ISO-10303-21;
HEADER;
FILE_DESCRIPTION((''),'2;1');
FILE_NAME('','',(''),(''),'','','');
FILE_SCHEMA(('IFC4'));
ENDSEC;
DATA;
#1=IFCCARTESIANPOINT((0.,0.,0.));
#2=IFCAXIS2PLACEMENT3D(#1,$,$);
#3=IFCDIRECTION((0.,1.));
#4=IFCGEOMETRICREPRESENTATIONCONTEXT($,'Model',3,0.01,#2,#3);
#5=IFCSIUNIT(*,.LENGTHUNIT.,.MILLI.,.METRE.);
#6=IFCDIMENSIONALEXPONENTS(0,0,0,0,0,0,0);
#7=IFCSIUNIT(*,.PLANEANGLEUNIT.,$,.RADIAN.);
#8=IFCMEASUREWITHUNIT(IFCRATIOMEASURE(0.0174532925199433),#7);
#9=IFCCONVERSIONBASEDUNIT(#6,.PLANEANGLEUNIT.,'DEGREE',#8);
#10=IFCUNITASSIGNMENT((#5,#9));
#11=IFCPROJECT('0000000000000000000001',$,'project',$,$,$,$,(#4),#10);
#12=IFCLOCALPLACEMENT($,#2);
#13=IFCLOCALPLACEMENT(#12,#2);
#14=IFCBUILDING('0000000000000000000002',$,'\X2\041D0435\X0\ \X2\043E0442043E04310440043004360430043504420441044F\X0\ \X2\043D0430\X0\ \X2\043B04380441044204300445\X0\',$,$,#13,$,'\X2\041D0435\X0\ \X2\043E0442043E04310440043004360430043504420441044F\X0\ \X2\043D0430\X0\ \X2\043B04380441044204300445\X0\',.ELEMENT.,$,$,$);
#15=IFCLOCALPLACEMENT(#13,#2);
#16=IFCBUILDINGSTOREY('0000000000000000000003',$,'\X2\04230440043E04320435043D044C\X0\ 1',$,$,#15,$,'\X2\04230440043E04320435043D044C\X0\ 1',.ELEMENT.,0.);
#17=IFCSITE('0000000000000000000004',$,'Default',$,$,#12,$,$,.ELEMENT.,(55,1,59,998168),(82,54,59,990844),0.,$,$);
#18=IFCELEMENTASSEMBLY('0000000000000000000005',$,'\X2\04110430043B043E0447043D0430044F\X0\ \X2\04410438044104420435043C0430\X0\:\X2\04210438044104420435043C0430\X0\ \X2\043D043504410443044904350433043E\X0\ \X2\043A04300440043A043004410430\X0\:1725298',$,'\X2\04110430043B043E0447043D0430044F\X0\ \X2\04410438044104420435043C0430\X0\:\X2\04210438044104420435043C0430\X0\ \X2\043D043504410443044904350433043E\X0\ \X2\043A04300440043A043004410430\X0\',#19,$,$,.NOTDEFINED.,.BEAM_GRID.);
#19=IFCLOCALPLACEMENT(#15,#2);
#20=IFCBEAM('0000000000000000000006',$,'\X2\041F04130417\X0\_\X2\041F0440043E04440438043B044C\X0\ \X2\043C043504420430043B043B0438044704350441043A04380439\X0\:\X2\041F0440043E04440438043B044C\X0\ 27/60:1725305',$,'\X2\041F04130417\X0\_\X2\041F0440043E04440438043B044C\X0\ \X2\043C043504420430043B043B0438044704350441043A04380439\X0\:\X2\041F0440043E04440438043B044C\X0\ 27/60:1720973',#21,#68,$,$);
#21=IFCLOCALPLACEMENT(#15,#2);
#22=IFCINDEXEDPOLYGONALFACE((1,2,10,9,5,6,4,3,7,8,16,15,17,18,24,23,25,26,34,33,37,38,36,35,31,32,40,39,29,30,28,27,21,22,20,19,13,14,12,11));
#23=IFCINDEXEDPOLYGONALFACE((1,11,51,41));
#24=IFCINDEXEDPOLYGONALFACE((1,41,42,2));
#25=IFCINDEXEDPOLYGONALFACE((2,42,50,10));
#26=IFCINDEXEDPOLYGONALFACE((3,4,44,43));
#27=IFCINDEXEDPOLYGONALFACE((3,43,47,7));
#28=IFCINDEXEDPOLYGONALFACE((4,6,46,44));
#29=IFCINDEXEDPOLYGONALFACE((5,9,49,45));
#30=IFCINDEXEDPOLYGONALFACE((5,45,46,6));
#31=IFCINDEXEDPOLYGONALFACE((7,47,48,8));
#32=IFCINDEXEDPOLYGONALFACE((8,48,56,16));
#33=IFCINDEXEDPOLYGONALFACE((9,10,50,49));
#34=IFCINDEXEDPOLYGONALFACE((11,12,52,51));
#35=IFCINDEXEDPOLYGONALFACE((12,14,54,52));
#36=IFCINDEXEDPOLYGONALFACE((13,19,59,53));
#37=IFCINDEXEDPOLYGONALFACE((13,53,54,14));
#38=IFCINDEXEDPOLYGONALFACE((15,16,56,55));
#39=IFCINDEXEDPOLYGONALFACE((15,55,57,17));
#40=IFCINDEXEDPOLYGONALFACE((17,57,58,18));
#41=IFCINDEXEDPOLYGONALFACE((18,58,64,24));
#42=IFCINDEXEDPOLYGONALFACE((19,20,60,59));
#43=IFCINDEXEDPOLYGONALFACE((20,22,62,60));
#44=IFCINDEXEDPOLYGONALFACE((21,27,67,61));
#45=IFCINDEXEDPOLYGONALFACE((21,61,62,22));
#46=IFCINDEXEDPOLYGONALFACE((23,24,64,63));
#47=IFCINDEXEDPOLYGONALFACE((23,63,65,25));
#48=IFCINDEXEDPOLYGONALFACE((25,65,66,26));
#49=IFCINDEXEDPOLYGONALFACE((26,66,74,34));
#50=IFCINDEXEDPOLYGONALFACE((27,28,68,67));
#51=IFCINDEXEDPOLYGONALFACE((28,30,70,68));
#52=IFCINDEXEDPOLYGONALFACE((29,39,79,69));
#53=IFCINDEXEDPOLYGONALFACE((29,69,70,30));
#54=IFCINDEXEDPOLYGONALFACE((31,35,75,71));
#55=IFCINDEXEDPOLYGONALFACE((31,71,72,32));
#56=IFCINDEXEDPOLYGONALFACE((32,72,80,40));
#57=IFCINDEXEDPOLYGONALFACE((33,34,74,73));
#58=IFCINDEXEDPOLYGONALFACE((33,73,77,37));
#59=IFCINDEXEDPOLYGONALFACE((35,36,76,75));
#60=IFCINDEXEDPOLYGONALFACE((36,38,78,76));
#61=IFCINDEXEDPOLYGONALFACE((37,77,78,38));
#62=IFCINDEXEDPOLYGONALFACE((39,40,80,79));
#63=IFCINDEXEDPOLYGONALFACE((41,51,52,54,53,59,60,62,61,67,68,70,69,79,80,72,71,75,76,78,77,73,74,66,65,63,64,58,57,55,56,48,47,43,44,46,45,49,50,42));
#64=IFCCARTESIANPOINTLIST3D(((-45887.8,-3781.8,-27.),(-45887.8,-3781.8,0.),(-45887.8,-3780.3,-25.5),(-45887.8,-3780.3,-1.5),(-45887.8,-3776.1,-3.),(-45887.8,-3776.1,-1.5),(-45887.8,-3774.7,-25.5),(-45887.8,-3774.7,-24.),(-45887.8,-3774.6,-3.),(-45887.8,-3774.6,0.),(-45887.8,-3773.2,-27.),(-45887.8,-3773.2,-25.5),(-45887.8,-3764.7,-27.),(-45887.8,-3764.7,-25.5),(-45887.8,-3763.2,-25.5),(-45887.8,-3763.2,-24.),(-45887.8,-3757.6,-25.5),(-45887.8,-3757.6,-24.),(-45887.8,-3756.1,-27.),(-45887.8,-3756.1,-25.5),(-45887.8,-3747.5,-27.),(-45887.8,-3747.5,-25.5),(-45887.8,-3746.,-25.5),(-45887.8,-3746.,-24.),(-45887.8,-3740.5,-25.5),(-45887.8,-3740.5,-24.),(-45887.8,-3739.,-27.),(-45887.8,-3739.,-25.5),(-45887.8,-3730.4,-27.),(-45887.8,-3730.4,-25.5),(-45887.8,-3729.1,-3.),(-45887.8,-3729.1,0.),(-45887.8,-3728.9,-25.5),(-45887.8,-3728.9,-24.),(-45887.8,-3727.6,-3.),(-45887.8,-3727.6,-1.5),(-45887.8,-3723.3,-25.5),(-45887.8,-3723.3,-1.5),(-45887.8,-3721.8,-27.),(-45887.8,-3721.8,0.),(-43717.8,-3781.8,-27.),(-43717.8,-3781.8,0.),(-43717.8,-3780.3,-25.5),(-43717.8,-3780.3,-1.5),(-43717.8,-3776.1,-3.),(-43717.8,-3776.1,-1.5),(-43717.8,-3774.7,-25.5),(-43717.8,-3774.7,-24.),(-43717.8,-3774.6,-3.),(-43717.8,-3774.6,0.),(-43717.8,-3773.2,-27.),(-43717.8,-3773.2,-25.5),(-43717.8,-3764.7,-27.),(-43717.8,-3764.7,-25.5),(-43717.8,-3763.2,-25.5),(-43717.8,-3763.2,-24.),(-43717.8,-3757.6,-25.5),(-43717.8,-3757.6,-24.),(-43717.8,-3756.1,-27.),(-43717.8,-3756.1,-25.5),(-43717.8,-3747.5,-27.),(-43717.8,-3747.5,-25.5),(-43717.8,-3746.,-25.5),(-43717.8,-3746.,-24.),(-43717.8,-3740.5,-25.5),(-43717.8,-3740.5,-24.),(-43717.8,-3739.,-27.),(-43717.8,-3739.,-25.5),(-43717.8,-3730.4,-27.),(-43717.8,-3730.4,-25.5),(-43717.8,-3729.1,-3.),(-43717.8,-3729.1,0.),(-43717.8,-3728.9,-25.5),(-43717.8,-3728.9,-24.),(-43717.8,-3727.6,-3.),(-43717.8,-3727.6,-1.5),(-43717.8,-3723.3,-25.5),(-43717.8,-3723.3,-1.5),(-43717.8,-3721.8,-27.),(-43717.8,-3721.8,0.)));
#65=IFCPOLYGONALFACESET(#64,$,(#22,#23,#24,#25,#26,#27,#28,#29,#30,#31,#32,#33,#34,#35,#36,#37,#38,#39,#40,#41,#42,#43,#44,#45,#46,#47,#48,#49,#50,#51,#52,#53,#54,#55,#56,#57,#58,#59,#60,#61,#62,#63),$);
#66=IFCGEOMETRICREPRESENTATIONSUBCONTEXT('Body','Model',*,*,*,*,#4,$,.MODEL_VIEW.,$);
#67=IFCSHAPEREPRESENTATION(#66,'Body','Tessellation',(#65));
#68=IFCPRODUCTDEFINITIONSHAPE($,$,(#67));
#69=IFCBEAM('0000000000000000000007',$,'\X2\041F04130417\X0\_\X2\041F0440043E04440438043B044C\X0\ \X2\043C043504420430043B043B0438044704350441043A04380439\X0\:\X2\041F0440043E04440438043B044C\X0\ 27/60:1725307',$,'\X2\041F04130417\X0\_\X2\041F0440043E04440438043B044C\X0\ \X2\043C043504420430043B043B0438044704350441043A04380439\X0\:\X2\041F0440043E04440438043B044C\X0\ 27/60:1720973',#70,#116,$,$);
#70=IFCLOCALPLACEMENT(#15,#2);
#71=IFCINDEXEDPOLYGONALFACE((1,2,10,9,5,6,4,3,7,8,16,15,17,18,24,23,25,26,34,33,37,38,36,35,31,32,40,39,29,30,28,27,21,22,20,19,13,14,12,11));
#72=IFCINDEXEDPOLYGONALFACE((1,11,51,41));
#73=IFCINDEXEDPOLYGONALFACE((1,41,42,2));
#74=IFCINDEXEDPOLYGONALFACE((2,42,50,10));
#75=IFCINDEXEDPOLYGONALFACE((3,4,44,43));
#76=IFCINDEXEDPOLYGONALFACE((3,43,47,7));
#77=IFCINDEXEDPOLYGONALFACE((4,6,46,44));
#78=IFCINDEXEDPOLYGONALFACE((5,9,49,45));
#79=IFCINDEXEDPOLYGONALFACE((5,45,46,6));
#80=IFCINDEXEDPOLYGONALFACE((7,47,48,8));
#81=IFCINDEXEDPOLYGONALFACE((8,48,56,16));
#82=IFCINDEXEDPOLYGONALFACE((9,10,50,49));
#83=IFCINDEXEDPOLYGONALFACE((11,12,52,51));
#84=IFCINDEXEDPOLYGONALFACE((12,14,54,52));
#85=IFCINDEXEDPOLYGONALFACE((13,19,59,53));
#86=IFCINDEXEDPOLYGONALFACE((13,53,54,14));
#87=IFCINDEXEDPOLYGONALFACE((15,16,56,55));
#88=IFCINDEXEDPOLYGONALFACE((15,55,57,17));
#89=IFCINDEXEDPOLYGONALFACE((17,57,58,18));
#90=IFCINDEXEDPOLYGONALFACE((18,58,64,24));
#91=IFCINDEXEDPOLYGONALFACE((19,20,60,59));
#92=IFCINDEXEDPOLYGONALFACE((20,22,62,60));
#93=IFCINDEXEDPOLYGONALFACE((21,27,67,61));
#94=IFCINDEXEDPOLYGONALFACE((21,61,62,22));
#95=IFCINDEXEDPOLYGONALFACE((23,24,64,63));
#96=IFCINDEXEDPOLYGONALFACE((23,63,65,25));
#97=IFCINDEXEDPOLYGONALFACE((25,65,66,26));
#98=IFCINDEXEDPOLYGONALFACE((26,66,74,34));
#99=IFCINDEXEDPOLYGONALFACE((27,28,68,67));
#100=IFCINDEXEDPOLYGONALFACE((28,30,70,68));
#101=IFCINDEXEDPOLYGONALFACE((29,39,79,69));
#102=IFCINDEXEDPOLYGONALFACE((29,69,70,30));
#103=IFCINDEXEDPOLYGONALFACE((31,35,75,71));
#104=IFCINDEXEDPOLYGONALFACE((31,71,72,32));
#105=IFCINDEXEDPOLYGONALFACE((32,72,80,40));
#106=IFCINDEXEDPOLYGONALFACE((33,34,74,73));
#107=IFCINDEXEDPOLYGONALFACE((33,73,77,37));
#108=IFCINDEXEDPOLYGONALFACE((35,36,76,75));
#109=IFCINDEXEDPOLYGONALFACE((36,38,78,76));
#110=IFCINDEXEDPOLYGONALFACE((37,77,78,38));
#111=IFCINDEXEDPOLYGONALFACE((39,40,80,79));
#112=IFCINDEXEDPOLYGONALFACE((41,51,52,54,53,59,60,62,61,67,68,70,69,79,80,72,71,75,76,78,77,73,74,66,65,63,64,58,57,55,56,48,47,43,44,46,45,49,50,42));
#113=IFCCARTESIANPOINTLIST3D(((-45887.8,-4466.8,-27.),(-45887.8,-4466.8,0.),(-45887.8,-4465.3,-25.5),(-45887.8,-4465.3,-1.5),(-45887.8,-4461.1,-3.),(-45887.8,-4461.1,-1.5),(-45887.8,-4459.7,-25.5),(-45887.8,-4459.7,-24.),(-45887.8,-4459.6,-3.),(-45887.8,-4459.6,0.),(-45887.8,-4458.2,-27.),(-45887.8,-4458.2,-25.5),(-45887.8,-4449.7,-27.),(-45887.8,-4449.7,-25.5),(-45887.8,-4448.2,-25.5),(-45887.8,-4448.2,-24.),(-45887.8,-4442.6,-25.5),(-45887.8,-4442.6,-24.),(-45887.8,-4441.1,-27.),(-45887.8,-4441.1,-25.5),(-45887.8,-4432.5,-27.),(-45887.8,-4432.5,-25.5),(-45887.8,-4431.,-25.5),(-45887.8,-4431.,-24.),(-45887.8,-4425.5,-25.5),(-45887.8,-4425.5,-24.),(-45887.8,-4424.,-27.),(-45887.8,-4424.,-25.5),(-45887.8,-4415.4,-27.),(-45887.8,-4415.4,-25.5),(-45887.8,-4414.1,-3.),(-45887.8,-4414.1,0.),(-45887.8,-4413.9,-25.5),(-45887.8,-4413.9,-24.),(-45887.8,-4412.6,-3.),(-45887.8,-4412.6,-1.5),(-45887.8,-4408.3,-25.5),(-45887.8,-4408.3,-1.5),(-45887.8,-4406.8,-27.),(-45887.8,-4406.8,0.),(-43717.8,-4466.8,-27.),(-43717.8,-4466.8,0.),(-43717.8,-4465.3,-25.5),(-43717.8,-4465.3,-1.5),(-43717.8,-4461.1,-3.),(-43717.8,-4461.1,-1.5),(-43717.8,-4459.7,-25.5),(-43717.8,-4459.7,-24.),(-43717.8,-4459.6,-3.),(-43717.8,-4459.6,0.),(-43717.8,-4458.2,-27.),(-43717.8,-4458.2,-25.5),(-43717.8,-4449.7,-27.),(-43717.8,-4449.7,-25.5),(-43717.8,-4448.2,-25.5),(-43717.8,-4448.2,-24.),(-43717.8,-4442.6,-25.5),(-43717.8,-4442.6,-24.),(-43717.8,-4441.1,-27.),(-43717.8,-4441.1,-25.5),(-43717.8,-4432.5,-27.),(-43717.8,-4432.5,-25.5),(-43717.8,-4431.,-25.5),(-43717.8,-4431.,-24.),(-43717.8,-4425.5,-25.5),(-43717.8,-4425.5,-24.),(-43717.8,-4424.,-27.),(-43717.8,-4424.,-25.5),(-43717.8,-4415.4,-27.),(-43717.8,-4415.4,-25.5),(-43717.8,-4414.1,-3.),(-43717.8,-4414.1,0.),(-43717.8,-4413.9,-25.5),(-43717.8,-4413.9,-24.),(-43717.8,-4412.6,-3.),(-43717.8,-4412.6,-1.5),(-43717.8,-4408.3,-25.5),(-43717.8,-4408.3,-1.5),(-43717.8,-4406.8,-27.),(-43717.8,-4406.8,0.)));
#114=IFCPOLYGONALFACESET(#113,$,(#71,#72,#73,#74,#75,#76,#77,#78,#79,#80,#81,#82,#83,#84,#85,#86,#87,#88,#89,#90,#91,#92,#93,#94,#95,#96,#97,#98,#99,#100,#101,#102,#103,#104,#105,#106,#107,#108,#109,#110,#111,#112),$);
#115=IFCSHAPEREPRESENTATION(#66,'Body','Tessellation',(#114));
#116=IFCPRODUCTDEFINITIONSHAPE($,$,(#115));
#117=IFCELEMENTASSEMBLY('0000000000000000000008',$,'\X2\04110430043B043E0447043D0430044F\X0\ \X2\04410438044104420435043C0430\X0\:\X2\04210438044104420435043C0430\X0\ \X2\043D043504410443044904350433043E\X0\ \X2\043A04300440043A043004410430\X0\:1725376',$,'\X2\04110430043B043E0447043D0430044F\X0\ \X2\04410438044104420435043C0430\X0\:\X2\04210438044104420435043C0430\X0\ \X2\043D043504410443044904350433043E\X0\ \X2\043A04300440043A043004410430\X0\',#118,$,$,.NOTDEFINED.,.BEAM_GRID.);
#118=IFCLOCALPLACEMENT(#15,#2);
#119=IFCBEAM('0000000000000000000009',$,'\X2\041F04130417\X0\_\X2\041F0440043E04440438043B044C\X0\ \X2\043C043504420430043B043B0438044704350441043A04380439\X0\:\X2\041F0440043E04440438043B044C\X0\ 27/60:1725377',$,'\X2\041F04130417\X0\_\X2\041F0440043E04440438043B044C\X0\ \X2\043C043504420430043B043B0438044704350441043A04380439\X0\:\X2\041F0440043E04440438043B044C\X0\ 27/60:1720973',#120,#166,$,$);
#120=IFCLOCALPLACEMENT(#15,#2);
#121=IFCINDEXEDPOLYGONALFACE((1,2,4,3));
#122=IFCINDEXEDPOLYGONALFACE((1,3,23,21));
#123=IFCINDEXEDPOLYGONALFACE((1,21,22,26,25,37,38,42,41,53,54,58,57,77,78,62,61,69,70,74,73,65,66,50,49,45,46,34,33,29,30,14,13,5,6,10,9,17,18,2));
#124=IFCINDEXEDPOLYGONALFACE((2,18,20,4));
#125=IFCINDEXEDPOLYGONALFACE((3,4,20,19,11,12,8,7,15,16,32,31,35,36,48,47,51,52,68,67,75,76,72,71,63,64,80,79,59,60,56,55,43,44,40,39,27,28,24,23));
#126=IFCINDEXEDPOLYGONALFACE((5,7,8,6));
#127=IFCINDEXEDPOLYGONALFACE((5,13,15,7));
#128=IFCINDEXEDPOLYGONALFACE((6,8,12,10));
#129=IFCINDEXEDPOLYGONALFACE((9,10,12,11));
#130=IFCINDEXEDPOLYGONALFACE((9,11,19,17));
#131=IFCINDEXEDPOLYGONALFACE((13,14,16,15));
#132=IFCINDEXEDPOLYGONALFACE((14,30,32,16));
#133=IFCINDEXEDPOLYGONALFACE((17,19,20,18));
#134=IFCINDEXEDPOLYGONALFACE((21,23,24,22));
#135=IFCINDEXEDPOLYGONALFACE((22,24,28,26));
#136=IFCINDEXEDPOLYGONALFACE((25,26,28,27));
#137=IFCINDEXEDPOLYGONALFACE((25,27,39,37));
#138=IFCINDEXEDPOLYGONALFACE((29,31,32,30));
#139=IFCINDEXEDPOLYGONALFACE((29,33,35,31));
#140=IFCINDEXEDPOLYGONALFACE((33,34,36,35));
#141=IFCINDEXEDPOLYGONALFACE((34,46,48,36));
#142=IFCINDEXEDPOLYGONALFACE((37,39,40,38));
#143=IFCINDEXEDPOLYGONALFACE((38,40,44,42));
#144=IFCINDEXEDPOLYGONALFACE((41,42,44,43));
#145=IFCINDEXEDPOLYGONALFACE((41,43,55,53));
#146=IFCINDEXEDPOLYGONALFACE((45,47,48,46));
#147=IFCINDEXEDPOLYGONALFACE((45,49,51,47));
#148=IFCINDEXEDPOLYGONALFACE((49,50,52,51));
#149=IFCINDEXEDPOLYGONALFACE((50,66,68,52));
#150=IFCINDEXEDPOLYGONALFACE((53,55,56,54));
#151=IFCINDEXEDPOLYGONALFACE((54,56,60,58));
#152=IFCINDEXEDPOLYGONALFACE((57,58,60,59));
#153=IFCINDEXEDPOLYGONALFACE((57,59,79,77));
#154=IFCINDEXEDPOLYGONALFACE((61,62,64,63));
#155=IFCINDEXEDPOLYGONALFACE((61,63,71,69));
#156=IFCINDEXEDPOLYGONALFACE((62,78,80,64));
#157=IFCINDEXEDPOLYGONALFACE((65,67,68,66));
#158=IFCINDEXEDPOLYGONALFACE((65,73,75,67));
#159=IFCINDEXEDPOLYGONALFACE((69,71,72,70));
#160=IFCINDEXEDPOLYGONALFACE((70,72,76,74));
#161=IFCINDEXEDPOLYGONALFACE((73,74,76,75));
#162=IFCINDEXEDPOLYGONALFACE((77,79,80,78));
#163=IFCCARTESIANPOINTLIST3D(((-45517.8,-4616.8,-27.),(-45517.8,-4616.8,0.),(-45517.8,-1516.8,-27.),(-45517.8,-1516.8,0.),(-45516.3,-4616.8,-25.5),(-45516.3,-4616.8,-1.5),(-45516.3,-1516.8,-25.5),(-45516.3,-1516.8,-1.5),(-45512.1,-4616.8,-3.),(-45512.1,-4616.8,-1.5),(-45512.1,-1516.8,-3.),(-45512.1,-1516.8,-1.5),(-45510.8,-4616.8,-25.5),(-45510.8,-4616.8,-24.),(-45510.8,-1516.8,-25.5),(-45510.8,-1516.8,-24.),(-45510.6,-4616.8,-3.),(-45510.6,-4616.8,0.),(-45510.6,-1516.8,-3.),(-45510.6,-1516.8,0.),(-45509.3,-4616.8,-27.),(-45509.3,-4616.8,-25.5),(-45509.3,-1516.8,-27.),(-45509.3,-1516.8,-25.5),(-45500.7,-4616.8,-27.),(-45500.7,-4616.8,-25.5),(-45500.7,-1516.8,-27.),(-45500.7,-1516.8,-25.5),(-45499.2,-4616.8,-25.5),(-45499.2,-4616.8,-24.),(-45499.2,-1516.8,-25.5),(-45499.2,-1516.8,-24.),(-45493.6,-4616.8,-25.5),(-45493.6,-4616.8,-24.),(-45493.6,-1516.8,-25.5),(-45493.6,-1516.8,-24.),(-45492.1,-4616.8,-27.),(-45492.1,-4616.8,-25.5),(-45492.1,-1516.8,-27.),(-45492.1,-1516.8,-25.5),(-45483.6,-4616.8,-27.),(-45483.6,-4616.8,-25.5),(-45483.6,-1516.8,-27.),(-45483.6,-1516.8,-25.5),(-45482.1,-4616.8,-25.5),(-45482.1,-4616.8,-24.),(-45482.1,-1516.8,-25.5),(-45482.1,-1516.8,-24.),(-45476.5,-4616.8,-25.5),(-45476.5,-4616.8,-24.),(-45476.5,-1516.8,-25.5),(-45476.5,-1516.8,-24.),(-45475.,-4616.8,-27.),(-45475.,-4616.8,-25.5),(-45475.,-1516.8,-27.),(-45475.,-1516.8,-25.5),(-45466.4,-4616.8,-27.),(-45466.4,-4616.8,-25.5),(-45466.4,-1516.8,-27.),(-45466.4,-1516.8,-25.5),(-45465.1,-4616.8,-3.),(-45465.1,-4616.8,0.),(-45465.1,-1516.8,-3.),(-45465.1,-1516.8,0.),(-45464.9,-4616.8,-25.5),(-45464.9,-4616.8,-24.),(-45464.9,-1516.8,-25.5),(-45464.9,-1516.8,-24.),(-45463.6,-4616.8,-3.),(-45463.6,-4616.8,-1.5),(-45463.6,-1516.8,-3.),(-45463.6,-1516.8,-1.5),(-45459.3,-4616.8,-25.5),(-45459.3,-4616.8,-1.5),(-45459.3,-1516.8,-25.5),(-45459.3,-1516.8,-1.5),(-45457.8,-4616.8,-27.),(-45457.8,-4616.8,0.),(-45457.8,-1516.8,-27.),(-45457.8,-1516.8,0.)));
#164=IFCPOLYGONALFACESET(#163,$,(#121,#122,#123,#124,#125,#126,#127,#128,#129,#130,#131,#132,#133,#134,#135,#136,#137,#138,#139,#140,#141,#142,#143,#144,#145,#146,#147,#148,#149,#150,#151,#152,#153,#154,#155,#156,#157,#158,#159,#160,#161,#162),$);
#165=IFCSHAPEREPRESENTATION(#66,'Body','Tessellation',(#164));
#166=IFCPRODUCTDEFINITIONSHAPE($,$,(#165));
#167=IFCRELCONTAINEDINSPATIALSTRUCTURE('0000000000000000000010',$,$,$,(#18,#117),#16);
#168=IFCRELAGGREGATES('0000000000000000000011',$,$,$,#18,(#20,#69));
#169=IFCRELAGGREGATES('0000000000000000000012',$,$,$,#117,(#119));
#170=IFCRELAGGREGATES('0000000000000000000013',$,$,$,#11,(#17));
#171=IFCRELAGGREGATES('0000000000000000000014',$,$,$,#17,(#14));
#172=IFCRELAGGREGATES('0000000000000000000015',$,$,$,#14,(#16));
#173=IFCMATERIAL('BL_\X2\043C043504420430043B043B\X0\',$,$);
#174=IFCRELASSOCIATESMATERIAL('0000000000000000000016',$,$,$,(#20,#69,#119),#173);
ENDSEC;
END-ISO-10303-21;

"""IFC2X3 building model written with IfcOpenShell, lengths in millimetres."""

from ifc_helpers import new_model, entity, si_unit, converted_unit, direction, frame, origin, place, context, subcontext, project, spatial, polyline, outline, extrude, material, element, aggregate, save


model = new_model("IFC2X3")

# Units and contexts
model_context = context("Model", 3, precision=0.01, world=origin(), true_north=direction((0.0, 1.0)))
body_context = subcontext(model_context, "Body", "Model", "MODEL_VIEW")
ifc_project = project(units=[si_unit("LENGTHUNIT", "METRE", prefix="MILLI"), converted_unit("PLANEANGLEUNIT", "DEGREE", entity("IfcRatioMeasure", 0.0174532925199433), si_unit("PLANEANGLEUNIT", "RADIAN"), dimensions=[0, 0, 0, 0, 0, 0, 0])], contexts=[model_context])

# Site, building, storey
site_placement = place(None, origin())
site = spatial("IfcSite", under=ifc_project, at=site_placement, Name="Default", CompositionType="ELEMENT", RefLatitude=(55, 1, 59, 998168), RefLongitude=(82, 54, 59, 990844), RefElevation=0.0)
building_placement = place(site_placement, origin())
building = spatial("IfcBuilding", under=site, at=building_placement, Name="Не отображается на листах", LongName="Не отображается на листах", CompositionType="ELEMENT")
storey_placement = place(building_placement, frame((0.0, 0.0, 0.0)))
storey = spatial("IfcBuildingStorey", under=building, at=storey_placement, Name="Уровень 1", LongName="Уровень 1", CompositionType="ELEMENT", Elevation=0.0)

# Element assemblies, beams
assembly_1_placement = place(storey_placement, origin())
assembly_1 = element("IfcElementAssembly", 1, at=assembly_1_placement, inside=storey, Name="Балочная система:Система несущего каркаса:1725298", ObjectType="Балочная система:Система несущего каркаса", AssemblyPlace="NOTDEFINED", PredefinedType="BEAM_GRID")
ifc_material_1 = material(Name="BL_металл")
beam_1_placement = place(assembly_1_placement, frame((-45887.8, -3751.8, 0.0)))
beam_1 = element("IfcBeam", 2, at=beam_1_placement, material=ifc_material_1, Name="ПГЗ_Профиль металлический:Профиль 27/60:1725305", ObjectType="ПГЗ_Профиль металлический:Профиль 27/60:1720973", context=body_context, shape_type="SweptSolid", body=[
    extrude(outline(polyline([(-18.4, -30.0), (8.6, -30.0), (8.6, -21.4), (7.1, -21.4), (7.1, -12.9), (8.6, -12.9), (8.6, -4.3), (7.1, -4.3), (7.1, 4.3), (8.6, 4.3), (8.6, 12.9), (7.1, 12.9), (7.1, 21.4), (8.6, 21.4), (8.6, 30.0), (-18.4, 30.0), (-18.4, 22.7), (-15.4, 22.7), (-15.4, 24.2), (-16.9, 24.2), (-16.9, 28.5), (7.1, 28.5), (7.1, 22.9), (5.6, 22.9), (5.6, 11.4), (7.1, 11.4), (7.1, 5.8), (5.6, 5.8), (5.6, -5.8), (7.1, -5.8), (7.1, -11.4), (5.6, -11.4), (5.6, -22.9), (7.1, -22.9), (7.1, -28.5), (-16.9, -28.5), (-16.9, -24.2), (-15.4, -24.2), (-15.4, -22.7), (-18.4, -22.7), (-18.4, -30.0)])), frame((0.0, 0.0, -18.4), z_axis=(1.0, 0.0, 0.0), x_axis=(0.0, 0.0, -1.0)), (0.0, 0.0, 1.0), 2170.0),
])
beam_2_placement = place(assembly_1_placement, frame((-45887.8, -4436.8, 0.0)))
beam_2 = element("IfcBeam", 3, at=beam_2_placement, material=ifc_material_1, Name="ПГЗ_Профиль металлический:Профиль 27/60:1725307", ObjectType="ПГЗ_Профиль металлический:Профиль 27/60:1720973", context=body_context, shape_type="SweptSolid", body=[
    extrude(outline(polyline([(-18.4, -30.0), (8.6, -30.0), (8.6, -21.4), (7.1, -21.4), (7.1, -12.9), (8.6, -12.9), (8.6, -4.3), (7.1, -4.3), (7.1, 4.3), (8.6, 4.3), (8.6, 12.9), (7.1, 12.9), (7.1, 21.4), (8.6, 21.4), (8.6, 30.0), (-18.4, 30.0), (-18.4, 22.7), (-15.4, 22.7), (-15.4, 24.2), (-16.9, 24.2), (-16.9, 28.5), (7.1, 28.5), (7.1, 22.9), (5.6, 22.9), (5.6, 11.4), (7.1, 11.4), (7.1, 5.8), (5.6, 5.8), (5.6, -5.8), (7.1, -5.8), (7.1, -11.4), (5.6, -11.4), (5.6, -22.9), (7.1, -22.9), (7.1, -28.5), (-16.9, -28.5), (-16.9, -24.2), (-15.4, -24.2), (-15.4, -22.7), (-18.4, -22.7), (-18.4, -30.0)])), frame((0.0, 0.0, -18.4), z_axis=(1.0, 0.0, 0.0), x_axis=(0.0, 0.0, -1.0)), (0.0, 0.0, 1.0), 2170.0),
])
aggregate(assembly_1, [beam_1, beam_2])
assembly_2_placement = place(storey_placement, origin())
assembly_2 = element("IfcElementAssembly", 4, at=assembly_2_placement, inside=storey, Name="Балочная система:Система несущего каркаса:1725376", ObjectType="Балочная система:Система несущего каркаса", AssemblyPlace="NOTDEFINED", PredefinedType="BEAM_GRID")
beam_3_placement = place(assembly_2_placement, frame((-45487.8, -4616.8, 0.0), z_axis=(0.0, 0.0, 1.0), x_axis=(0.0, 1.0, 0.0)))
beam_3 = element("IfcBeam", 5, at=beam_3_placement, material=ifc_material_1, Name="ПГЗ_Профиль металлический:Профиль 27/60:1725377", ObjectType="ПГЗ_Профиль металлический:Профиль 27/60:1720973", context=body_context, shape_type="SweptSolid", body=[
    extrude(outline(polyline([(-18.4, -30.0), (8.6, -30.0), (8.6, -21.4), (7.1, -21.4), (7.1, -12.9), (8.6, -12.9), (8.6, -4.3), (7.1, -4.3), (7.1, 4.3), (8.6, 4.3), (8.6, 12.9), (7.1, 12.9), (7.1, 21.4), (8.6, 21.4), (8.6, 30.0), (-18.4, 30.0), (-18.4, 22.7), (-15.4, 22.7), (-15.4, 24.2), (-16.9, 24.2), (-16.9, 28.5), (7.1, 28.5), (7.1, 22.9), (5.6, 22.9), (5.6, 11.4), (7.1, 11.4), (7.1, 5.8), (5.6, 5.8), (5.6, -5.8), (7.1, -5.8), (7.1, -11.4), (5.6, -11.4), (5.6, -22.9), (7.1, -22.9), (7.1, -28.5), (-16.9, -28.5), (-16.9, -24.2), (-15.4, -24.2), (-15.4, -22.7), (-18.4, -22.7), (-18.4, -30.0)])), frame((0.0, 0.0, -18.4), z_axis=(1.0, 0.0, 0.0), x_axis=(0.0, 0.0, -1.0)), (0.0, 0.0, 1.0), 3100.0),
])
aggregate(assembly_2, [beam_3])

save(model, "model.ifc")
